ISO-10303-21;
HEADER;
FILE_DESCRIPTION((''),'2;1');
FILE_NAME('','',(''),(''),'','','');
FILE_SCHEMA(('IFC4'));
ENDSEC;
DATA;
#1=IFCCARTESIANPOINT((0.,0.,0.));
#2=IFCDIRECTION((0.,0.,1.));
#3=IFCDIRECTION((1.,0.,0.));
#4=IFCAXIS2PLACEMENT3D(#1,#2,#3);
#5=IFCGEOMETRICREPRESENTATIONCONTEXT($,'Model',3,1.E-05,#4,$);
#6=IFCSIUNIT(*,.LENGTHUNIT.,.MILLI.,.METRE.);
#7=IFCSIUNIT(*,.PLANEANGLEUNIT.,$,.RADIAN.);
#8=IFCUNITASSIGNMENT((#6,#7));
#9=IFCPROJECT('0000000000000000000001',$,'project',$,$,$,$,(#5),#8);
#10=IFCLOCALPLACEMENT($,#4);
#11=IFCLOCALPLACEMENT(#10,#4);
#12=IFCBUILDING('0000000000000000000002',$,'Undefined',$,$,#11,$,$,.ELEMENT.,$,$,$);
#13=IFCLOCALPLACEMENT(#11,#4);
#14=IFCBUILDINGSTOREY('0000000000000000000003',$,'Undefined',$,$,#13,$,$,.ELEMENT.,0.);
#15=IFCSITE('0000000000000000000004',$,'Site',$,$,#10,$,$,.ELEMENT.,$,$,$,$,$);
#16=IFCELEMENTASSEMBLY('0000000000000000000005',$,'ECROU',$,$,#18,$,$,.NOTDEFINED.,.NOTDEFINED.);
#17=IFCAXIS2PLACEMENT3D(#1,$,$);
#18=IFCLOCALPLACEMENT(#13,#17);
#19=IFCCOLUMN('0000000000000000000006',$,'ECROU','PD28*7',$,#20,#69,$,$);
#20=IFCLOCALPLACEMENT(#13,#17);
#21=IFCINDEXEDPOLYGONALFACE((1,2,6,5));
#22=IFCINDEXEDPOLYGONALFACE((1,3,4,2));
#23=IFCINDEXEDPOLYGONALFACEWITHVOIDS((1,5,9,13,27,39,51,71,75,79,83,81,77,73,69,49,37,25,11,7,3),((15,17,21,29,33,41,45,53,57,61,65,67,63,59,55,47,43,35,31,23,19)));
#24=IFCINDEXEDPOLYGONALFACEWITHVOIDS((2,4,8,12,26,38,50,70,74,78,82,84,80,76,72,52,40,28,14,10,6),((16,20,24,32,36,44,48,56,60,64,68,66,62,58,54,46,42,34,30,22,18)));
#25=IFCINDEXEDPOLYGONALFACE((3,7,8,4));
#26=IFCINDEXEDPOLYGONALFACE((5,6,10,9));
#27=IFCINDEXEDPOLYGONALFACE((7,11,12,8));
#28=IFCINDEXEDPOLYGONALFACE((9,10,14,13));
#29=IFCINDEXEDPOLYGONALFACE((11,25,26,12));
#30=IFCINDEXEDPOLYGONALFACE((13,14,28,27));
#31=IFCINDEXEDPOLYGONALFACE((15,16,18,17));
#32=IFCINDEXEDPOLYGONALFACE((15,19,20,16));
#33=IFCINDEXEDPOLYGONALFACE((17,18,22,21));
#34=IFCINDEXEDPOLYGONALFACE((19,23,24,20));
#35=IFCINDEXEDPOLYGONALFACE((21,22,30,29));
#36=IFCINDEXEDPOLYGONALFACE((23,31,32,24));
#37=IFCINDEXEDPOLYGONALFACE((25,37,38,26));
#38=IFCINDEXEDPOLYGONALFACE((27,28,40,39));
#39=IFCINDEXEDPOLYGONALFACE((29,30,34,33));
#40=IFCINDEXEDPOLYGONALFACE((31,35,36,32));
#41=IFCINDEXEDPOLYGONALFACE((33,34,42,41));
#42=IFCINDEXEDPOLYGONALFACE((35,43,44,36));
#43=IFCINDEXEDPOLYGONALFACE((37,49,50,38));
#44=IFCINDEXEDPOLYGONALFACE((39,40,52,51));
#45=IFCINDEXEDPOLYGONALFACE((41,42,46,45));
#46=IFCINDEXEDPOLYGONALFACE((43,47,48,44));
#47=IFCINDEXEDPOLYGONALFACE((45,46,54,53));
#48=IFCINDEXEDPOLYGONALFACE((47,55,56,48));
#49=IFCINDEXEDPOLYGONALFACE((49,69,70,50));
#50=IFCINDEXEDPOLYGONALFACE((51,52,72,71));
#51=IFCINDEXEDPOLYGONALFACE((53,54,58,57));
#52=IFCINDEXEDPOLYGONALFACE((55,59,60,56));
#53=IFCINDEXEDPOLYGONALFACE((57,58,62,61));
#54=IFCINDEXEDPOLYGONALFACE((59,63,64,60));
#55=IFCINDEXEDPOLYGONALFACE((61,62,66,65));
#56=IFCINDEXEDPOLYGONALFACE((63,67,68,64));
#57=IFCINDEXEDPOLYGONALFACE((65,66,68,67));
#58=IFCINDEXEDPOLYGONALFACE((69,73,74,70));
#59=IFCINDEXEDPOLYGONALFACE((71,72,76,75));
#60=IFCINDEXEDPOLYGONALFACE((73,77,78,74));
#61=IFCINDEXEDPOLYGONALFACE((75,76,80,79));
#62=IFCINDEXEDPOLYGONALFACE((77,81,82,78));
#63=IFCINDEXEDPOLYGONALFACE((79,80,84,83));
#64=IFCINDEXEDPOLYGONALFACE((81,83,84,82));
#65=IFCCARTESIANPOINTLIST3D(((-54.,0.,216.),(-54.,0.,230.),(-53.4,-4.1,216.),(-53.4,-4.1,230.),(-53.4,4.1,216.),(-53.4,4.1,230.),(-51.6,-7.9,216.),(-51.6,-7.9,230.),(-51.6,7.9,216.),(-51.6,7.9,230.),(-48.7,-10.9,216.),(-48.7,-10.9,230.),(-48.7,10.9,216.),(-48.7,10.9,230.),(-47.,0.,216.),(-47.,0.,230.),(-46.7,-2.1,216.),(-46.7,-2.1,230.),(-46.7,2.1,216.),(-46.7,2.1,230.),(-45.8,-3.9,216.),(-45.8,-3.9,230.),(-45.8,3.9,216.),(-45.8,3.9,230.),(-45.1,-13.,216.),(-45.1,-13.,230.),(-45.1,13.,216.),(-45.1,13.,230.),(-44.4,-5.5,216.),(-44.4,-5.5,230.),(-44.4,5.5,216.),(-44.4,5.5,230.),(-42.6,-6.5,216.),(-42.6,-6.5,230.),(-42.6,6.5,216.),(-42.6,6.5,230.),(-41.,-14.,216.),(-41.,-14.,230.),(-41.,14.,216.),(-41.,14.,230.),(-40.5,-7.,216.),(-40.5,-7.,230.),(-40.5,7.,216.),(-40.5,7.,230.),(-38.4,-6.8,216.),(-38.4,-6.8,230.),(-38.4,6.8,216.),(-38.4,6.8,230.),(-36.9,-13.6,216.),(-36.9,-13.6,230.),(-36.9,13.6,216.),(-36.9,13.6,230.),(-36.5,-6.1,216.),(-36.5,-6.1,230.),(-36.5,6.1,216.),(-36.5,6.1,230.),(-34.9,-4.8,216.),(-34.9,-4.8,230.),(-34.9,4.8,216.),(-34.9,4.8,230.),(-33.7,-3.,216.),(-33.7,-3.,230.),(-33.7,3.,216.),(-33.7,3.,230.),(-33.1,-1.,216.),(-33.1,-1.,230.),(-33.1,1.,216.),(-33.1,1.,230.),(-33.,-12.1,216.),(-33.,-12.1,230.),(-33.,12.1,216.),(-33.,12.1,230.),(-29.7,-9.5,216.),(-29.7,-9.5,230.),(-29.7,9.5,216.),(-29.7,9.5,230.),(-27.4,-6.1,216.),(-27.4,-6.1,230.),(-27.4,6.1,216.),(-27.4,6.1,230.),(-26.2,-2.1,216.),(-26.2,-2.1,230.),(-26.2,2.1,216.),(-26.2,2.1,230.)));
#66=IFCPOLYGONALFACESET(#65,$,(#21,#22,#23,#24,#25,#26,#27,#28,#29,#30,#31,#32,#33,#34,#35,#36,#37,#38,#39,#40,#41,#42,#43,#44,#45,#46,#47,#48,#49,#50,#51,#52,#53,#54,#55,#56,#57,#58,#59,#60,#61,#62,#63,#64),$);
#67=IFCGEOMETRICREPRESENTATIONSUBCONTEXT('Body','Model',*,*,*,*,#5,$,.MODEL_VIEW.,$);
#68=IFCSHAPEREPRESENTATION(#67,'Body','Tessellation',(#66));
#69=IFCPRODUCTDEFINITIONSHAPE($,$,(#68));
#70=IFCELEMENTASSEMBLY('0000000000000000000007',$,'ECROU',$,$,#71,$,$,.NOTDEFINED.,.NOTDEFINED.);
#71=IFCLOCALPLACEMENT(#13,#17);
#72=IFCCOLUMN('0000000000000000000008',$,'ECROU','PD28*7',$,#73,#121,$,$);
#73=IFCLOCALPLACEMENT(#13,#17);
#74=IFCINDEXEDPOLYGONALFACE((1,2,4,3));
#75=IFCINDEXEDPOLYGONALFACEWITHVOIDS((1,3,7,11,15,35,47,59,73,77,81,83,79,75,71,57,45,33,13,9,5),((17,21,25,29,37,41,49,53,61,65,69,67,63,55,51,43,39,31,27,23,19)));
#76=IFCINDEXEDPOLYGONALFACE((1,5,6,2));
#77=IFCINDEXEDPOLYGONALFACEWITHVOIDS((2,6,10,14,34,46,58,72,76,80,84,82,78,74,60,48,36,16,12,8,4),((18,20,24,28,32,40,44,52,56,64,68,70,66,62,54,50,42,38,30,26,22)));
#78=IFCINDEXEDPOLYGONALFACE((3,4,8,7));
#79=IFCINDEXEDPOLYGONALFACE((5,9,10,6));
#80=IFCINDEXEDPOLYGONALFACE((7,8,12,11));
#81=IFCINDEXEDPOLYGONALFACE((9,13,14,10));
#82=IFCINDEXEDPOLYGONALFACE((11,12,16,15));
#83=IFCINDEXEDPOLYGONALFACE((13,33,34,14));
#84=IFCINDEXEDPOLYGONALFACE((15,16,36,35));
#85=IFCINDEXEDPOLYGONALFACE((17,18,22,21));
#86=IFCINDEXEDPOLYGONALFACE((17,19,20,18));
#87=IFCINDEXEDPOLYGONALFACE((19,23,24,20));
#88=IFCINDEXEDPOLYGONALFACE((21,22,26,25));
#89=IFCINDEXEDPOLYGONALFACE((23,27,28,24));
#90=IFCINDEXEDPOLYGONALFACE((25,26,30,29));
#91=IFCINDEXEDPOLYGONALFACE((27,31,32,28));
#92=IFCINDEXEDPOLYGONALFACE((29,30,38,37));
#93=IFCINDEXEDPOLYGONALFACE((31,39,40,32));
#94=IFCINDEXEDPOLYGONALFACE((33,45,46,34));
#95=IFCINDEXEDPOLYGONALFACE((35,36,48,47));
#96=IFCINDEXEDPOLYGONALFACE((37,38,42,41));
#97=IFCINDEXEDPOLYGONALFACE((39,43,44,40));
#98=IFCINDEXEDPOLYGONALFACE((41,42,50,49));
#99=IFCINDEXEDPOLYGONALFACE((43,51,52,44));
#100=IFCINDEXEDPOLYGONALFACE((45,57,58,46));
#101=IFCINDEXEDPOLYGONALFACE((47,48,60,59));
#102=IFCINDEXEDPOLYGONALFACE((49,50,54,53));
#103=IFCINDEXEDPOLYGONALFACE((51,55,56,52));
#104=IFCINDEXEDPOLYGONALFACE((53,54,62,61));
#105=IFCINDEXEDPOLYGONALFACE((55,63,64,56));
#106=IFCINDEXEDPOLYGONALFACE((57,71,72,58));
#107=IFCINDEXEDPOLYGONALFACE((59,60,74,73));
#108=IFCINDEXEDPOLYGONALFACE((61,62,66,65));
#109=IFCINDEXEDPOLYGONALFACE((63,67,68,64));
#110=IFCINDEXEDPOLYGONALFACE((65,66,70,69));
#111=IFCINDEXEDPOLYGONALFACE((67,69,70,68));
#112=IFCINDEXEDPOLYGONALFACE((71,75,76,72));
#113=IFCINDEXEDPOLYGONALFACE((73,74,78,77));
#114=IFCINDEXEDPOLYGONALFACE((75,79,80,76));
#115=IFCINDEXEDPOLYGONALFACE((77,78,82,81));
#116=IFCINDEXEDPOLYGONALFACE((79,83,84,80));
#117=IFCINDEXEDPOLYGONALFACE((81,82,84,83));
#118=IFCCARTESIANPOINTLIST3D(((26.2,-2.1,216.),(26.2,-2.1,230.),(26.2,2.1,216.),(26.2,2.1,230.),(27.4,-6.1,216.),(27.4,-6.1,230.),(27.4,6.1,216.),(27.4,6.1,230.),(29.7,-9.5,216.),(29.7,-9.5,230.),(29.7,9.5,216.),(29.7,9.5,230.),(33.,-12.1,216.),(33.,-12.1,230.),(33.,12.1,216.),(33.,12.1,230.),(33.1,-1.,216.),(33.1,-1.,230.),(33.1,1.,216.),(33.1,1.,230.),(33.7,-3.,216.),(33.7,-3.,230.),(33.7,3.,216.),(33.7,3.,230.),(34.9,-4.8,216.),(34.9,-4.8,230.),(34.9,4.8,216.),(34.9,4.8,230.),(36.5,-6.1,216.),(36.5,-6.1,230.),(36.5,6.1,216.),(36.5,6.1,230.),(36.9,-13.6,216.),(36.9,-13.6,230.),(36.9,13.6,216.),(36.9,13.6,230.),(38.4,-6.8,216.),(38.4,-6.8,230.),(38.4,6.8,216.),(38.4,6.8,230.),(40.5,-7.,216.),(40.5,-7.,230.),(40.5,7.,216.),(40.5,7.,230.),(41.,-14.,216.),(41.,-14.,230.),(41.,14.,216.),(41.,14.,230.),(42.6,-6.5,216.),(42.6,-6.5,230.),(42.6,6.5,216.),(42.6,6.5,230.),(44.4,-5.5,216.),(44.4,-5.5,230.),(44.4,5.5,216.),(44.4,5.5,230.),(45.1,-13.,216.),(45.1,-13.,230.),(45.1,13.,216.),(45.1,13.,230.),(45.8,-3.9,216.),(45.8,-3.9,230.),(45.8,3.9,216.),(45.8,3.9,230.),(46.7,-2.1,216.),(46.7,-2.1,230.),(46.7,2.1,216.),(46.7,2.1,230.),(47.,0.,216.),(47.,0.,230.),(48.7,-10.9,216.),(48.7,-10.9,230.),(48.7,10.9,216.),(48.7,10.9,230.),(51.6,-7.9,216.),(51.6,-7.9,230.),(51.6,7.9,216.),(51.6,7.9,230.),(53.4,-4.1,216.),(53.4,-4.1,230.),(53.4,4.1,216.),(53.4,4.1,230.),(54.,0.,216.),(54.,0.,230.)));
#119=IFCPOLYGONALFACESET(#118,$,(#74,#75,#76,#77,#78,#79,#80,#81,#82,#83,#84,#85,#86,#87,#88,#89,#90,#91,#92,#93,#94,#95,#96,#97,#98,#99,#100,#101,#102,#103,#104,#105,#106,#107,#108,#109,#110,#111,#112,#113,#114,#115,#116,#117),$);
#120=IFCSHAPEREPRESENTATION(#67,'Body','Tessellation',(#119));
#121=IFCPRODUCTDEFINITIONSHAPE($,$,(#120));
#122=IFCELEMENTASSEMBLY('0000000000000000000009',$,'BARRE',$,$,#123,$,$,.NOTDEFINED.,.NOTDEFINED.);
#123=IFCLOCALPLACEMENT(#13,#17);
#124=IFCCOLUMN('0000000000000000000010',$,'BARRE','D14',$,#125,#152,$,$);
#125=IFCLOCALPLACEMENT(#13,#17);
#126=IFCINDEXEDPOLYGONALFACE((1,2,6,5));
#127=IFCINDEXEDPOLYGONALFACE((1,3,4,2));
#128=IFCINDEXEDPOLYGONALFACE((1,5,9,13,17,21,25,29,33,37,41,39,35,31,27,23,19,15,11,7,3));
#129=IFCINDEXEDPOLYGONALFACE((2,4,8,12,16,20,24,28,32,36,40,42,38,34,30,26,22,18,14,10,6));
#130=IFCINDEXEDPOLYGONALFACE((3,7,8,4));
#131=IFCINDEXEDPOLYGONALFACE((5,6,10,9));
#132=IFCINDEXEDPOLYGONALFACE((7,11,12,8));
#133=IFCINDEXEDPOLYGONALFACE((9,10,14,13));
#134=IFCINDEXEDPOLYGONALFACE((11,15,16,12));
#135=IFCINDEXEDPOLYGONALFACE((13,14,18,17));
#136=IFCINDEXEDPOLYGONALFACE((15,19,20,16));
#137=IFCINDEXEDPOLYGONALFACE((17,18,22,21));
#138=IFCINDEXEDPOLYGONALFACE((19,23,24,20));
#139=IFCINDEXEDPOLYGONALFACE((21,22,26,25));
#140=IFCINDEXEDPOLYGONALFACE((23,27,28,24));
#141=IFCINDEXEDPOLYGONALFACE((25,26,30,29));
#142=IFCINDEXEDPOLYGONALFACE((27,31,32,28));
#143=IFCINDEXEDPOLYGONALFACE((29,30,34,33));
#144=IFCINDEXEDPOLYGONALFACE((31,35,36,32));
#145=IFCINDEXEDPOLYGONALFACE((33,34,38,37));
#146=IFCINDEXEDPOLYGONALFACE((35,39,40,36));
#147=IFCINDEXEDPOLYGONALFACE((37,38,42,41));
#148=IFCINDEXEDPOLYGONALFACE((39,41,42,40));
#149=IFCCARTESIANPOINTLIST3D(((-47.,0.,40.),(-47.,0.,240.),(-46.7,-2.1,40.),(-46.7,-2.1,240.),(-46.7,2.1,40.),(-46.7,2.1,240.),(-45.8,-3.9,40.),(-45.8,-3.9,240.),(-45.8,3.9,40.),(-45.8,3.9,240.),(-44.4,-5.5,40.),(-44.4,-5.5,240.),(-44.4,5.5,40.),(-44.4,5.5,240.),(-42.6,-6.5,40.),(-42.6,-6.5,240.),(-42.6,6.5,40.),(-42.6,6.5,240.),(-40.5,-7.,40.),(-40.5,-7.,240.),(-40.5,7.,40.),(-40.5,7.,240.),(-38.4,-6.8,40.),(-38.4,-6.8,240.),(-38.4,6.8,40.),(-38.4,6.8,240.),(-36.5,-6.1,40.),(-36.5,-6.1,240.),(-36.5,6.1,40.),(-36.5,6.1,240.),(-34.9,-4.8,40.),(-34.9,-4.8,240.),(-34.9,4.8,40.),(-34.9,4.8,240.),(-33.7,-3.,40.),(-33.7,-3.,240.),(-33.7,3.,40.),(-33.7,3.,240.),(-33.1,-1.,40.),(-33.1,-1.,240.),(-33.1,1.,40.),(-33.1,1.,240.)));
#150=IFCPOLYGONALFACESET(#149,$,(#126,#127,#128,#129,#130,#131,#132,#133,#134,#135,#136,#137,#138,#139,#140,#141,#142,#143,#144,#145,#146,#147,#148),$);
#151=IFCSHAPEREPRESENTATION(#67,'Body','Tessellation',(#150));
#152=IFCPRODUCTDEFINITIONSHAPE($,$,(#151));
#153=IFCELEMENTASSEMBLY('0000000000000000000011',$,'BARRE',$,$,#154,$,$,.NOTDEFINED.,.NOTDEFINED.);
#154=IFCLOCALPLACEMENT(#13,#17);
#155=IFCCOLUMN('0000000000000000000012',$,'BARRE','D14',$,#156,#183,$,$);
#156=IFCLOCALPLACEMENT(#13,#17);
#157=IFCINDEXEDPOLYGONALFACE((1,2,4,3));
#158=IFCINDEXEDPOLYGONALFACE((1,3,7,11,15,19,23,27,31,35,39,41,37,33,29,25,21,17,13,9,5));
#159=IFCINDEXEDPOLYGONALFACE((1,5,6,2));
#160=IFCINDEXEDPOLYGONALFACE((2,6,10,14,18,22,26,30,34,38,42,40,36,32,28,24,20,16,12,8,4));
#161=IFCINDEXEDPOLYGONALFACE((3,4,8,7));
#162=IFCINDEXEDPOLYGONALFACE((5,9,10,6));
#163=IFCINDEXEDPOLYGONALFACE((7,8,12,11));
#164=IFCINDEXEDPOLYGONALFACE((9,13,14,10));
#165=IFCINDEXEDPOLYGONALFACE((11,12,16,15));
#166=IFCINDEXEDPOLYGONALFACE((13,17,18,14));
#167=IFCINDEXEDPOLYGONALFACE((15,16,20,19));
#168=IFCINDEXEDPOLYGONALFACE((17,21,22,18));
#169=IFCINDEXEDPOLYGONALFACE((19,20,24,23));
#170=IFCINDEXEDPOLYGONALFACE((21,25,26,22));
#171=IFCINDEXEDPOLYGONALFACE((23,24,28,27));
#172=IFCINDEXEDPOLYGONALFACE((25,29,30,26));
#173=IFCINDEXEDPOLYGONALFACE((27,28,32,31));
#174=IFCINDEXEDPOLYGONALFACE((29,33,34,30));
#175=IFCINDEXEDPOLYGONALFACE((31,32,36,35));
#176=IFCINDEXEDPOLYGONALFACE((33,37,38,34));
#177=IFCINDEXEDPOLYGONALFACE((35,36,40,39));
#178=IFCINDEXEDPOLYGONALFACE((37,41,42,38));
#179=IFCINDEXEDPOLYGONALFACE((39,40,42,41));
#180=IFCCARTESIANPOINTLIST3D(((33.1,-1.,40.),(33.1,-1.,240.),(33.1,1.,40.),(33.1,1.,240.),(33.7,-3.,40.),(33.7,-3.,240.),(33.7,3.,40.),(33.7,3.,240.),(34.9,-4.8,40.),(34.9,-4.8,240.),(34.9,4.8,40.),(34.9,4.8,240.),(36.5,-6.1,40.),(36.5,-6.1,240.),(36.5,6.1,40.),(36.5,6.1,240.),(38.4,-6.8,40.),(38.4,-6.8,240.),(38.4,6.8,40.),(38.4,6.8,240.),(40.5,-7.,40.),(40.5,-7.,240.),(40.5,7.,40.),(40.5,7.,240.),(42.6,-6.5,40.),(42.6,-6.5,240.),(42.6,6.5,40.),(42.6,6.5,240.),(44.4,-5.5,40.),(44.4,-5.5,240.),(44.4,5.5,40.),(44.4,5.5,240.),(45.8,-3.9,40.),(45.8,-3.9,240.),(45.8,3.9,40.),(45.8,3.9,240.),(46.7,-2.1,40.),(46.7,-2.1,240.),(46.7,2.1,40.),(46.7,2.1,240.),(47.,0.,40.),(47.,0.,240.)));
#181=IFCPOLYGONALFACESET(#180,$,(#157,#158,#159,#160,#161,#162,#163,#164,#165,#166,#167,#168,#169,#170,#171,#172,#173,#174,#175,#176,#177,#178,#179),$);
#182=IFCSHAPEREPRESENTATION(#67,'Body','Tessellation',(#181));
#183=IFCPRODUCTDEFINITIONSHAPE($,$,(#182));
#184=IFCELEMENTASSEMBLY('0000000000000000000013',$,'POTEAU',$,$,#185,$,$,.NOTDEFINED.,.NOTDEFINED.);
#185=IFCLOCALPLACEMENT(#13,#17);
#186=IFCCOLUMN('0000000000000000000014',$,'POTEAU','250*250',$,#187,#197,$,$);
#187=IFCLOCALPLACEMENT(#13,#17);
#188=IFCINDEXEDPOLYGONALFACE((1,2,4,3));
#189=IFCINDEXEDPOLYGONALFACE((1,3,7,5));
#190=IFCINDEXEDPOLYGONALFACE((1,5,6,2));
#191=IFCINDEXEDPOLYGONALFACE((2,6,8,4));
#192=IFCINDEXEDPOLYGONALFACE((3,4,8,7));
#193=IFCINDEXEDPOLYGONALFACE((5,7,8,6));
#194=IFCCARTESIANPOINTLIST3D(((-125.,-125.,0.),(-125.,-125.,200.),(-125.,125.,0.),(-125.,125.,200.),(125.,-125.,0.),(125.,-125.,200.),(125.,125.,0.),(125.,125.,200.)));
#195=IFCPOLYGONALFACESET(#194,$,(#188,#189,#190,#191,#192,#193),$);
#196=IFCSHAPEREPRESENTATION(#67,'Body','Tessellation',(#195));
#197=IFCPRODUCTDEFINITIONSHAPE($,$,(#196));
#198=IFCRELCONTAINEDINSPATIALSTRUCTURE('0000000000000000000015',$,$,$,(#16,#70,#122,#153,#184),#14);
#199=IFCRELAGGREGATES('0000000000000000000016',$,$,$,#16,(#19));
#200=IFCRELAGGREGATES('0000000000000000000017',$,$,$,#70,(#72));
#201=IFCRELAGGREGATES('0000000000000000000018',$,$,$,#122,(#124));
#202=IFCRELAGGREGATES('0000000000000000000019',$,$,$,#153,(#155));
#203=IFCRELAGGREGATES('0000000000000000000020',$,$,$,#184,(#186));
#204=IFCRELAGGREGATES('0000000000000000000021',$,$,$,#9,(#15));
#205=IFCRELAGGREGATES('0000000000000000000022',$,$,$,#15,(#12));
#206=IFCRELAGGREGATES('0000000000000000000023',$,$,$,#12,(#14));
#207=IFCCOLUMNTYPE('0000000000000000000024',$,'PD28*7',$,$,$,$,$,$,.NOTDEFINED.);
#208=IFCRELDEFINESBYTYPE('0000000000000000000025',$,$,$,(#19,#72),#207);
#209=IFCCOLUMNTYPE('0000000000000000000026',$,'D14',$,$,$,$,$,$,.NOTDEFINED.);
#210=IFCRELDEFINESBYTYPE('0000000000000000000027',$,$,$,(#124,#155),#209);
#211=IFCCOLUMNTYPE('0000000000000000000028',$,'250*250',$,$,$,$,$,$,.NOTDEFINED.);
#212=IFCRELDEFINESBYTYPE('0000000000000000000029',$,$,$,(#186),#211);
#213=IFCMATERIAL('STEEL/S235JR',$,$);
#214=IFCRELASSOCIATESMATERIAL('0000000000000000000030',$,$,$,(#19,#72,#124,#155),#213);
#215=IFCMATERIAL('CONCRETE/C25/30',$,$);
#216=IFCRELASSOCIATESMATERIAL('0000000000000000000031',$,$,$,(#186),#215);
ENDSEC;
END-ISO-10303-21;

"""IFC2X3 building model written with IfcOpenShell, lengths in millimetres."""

from ifc_helpers import new_model, si_unit, frame, origin_with_axes, origin_2d_with_axis, place, context, subcontext, project, spatial, rectangle, circle, hollow_circle, extrude, material, type_object, element, aggregate, save


model = new_model("IFC2X3")

# Units and contexts
model_context = context("Model", 3, precision=1e-05, world=origin_with_axes())
body_context = subcontext(model_context, "Body", "Model", "MODEL_VIEW")
ifc_project = project(units=[si_unit("LENGTHUNIT", "METRE", prefix="MILLI"), si_unit("PLANEANGLEUNIT", "RADIAN")], contexts=[model_context])

# Site, building, storey
site_placement = place(None, origin_with_axes())
site = spatial("IfcSite", under=ifc_project, at=site_placement, Name="Site", CompositionType="ELEMENT")
building_placement = place(site_placement, origin_with_axes())
building = spatial("IfcBuilding", under=site, at=building_placement, Name="Undefined", CompositionType="ELEMENT")
storey_placement = place(building_placement, origin_with_axes())
storey = spatial("IfcBuildingStorey", under=building, at=storey_placement, Name="Undefined", CompositionType="ELEMENT", Elevation=0.0)

# Element assemblies, columns
assembly_1_placement = place(storey_placement, origin_with_axes())
assembly_1 = element("IfcElementAssembly", 1, at=assembly_1_placement, inside=storey, Name="ECROU", AssemblyPlace="NOTDEFINED", PredefinedType="NOTDEFINED")
ifc_material_1 = material(Name="STEEL/S235JR")
column_type_1 = type_object("IfcColumnType", Name="PD28*7", PredefinedType="NOTDEFINED")
column_1_placement = place(assembly_1_placement, frame((-40.0, 0.0, 230.0), z_axis=(0.0, 0.0, -1.0), x_axis=(0.0, -1.0, 0.0)))
column_1 = element("IfcColumn", 2, at=column_1_placement, type_object=column_type_1, material=ifc_material_1, Name="ECROU", Description="PD28*7", context=body_context, shape_type="SweptSolid", body=[
    extrude(hollow_circle(Radius=14.0, WallThickness=7.0, at=origin_2d_with_axis()), frame((0.0, 0.0, 14.0), z_axis=(0.0, 0.0, -1.0), x_axis=(0.0, 1.0, 0.0)), (0.0, 0.0, 1.0), 14.0),
])
aggregate(assembly_1, [column_1])
assembly_2_placement = place(storey_placement, origin_with_axes())
assembly_2 = element("IfcElementAssembly", 3, at=assembly_2_placement, inside=storey, Name="ECROU", AssemblyPlace="NOTDEFINED", PredefinedType="NOTDEFINED")
column_2_placement = place(assembly_2_placement, frame((40.0, 0.0, 230.0), z_axis=(0.0, 0.0, -1.0), x_axis=(0.0, 1.0, 0.0)))
column_2 = element("IfcColumn", 4, at=column_2_placement, type_object=column_type_1, material=ifc_material_1, Name="ECROU", Description="PD28*7", context=body_context, shape_type="SweptSolid", body=[
    extrude(hollow_circle(Radius=14.0, WallThickness=7.0, at=origin_2d_with_axis()), frame((0.0, 0.0, 14.0), z_axis=(0.0, 0.0, -1.0), x_axis=(0.0, 1.0, 0.0)), (0.0, 0.0, 1.0), 14.0),
])
aggregate(assembly_2, [column_2])
assembly_3_placement = place(storey_placement, origin_with_axes())
assembly_3 = element("IfcElementAssembly", 5, at=assembly_3_placement, inside=storey, Name="BARRE", AssemblyPlace="NOTDEFINED", PredefinedType="NOTDEFINED")
column_type_2 = type_object("IfcColumnType", Name="D14", PredefinedType="NOTDEFINED")
column_3_placement = place(assembly_3_placement, frame((-40.0, 0.0, 240.0), z_axis=(0.0, 0.0, -1.0), x_axis=(0.0, -1.0, 0.0)))
column_3 = element("IfcColumn", 6, at=column_3_placement, type_object=column_type_2, material=ifc_material_1, Name="BARRE", Description="D14", context=body_context, shape_type="SweptSolid", body=[
    extrude(circle(Radius=7.0, at=origin_2d_with_axis()), frame((0.0, 0.0, 200.0), z_axis=(0.0, 0.0, -1.0), x_axis=(0.0, 1.0, 0.0)), (0.0, 0.0, 1.0), 200.0),
])
aggregate(assembly_3, [column_3])
assembly_4_placement = place(storey_placement, origin_with_axes())
assembly_4 = element("IfcElementAssembly", 7, at=assembly_4_placement, inside=storey, Name="BARRE", AssemblyPlace="NOTDEFINED", PredefinedType="NOTDEFINED")
column_4_placement = place(assembly_4_placement, frame((40.0, 0.0, 240.0), z_axis=(0.0, 0.0, -1.0), x_axis=(0.0, 1.0, 0.0)))
column_4 = element("IfcColumn", 8, at=column_4_placement, type_object=column_type_2, material=ifc_material_1, Name="BARRE", Description="D14", context=body_context, shape_type="SweptSolid", body=[
    extrude(circle(Radius=7.0, at=origin_2d_with_axis()), frame((0.0, 0.0, 200.0), z_axis=(0.0, 0.0, -1.0), x_axis=(0.0, 1.0, 0.0)), (0.0, 0.0, 1.0), 200.0),
])
aggregate(assembly_4, [column_4])
assembly_5_placement = place(storey_placement, origin_with_axes())
assembly_5 = element("IfcElementAssembly", 9, at=assembly_5_placement, inside=storey, Name="POTEAU", AssemblyPlace="NOTDEFINED", PredefinedType="NOTDEFINED")
ifc_material_2 = material(Name="CONCRETE/C25/30")
column_type_3 = type_object("IfcColumnType", Name="250*250", PredefinedType="NOTDEFINED")
column_5_placement = place(assembly_5_placement, frame((0.0, 0.0, 0.0), z_axis=(0.0, 0.0, 1.0), x_axis=(0.0, 1.0, 0.0)))
column_5 = element("IfcColumn", 10, at=column_5_placement, type_object=column_type_3, material=ifc_material_2, Name="POTEAU", Description="250*250", context=body_context, shape_type="SweptSolid", body=[
    extrude(rectangle(XDim=250.0, YDim=250.0, at=origin_2d_with_axis()), frame((0.0, 0.0, 200.0), z_axis=(0.0, 0.0, -1.0), x_axis=(0.0, 1.0, 0.0)), (0.0, 0.0, 1.0), 200.0),
])
aggregate(assembly_5, [column_5])

save(model, "model.ifc")
